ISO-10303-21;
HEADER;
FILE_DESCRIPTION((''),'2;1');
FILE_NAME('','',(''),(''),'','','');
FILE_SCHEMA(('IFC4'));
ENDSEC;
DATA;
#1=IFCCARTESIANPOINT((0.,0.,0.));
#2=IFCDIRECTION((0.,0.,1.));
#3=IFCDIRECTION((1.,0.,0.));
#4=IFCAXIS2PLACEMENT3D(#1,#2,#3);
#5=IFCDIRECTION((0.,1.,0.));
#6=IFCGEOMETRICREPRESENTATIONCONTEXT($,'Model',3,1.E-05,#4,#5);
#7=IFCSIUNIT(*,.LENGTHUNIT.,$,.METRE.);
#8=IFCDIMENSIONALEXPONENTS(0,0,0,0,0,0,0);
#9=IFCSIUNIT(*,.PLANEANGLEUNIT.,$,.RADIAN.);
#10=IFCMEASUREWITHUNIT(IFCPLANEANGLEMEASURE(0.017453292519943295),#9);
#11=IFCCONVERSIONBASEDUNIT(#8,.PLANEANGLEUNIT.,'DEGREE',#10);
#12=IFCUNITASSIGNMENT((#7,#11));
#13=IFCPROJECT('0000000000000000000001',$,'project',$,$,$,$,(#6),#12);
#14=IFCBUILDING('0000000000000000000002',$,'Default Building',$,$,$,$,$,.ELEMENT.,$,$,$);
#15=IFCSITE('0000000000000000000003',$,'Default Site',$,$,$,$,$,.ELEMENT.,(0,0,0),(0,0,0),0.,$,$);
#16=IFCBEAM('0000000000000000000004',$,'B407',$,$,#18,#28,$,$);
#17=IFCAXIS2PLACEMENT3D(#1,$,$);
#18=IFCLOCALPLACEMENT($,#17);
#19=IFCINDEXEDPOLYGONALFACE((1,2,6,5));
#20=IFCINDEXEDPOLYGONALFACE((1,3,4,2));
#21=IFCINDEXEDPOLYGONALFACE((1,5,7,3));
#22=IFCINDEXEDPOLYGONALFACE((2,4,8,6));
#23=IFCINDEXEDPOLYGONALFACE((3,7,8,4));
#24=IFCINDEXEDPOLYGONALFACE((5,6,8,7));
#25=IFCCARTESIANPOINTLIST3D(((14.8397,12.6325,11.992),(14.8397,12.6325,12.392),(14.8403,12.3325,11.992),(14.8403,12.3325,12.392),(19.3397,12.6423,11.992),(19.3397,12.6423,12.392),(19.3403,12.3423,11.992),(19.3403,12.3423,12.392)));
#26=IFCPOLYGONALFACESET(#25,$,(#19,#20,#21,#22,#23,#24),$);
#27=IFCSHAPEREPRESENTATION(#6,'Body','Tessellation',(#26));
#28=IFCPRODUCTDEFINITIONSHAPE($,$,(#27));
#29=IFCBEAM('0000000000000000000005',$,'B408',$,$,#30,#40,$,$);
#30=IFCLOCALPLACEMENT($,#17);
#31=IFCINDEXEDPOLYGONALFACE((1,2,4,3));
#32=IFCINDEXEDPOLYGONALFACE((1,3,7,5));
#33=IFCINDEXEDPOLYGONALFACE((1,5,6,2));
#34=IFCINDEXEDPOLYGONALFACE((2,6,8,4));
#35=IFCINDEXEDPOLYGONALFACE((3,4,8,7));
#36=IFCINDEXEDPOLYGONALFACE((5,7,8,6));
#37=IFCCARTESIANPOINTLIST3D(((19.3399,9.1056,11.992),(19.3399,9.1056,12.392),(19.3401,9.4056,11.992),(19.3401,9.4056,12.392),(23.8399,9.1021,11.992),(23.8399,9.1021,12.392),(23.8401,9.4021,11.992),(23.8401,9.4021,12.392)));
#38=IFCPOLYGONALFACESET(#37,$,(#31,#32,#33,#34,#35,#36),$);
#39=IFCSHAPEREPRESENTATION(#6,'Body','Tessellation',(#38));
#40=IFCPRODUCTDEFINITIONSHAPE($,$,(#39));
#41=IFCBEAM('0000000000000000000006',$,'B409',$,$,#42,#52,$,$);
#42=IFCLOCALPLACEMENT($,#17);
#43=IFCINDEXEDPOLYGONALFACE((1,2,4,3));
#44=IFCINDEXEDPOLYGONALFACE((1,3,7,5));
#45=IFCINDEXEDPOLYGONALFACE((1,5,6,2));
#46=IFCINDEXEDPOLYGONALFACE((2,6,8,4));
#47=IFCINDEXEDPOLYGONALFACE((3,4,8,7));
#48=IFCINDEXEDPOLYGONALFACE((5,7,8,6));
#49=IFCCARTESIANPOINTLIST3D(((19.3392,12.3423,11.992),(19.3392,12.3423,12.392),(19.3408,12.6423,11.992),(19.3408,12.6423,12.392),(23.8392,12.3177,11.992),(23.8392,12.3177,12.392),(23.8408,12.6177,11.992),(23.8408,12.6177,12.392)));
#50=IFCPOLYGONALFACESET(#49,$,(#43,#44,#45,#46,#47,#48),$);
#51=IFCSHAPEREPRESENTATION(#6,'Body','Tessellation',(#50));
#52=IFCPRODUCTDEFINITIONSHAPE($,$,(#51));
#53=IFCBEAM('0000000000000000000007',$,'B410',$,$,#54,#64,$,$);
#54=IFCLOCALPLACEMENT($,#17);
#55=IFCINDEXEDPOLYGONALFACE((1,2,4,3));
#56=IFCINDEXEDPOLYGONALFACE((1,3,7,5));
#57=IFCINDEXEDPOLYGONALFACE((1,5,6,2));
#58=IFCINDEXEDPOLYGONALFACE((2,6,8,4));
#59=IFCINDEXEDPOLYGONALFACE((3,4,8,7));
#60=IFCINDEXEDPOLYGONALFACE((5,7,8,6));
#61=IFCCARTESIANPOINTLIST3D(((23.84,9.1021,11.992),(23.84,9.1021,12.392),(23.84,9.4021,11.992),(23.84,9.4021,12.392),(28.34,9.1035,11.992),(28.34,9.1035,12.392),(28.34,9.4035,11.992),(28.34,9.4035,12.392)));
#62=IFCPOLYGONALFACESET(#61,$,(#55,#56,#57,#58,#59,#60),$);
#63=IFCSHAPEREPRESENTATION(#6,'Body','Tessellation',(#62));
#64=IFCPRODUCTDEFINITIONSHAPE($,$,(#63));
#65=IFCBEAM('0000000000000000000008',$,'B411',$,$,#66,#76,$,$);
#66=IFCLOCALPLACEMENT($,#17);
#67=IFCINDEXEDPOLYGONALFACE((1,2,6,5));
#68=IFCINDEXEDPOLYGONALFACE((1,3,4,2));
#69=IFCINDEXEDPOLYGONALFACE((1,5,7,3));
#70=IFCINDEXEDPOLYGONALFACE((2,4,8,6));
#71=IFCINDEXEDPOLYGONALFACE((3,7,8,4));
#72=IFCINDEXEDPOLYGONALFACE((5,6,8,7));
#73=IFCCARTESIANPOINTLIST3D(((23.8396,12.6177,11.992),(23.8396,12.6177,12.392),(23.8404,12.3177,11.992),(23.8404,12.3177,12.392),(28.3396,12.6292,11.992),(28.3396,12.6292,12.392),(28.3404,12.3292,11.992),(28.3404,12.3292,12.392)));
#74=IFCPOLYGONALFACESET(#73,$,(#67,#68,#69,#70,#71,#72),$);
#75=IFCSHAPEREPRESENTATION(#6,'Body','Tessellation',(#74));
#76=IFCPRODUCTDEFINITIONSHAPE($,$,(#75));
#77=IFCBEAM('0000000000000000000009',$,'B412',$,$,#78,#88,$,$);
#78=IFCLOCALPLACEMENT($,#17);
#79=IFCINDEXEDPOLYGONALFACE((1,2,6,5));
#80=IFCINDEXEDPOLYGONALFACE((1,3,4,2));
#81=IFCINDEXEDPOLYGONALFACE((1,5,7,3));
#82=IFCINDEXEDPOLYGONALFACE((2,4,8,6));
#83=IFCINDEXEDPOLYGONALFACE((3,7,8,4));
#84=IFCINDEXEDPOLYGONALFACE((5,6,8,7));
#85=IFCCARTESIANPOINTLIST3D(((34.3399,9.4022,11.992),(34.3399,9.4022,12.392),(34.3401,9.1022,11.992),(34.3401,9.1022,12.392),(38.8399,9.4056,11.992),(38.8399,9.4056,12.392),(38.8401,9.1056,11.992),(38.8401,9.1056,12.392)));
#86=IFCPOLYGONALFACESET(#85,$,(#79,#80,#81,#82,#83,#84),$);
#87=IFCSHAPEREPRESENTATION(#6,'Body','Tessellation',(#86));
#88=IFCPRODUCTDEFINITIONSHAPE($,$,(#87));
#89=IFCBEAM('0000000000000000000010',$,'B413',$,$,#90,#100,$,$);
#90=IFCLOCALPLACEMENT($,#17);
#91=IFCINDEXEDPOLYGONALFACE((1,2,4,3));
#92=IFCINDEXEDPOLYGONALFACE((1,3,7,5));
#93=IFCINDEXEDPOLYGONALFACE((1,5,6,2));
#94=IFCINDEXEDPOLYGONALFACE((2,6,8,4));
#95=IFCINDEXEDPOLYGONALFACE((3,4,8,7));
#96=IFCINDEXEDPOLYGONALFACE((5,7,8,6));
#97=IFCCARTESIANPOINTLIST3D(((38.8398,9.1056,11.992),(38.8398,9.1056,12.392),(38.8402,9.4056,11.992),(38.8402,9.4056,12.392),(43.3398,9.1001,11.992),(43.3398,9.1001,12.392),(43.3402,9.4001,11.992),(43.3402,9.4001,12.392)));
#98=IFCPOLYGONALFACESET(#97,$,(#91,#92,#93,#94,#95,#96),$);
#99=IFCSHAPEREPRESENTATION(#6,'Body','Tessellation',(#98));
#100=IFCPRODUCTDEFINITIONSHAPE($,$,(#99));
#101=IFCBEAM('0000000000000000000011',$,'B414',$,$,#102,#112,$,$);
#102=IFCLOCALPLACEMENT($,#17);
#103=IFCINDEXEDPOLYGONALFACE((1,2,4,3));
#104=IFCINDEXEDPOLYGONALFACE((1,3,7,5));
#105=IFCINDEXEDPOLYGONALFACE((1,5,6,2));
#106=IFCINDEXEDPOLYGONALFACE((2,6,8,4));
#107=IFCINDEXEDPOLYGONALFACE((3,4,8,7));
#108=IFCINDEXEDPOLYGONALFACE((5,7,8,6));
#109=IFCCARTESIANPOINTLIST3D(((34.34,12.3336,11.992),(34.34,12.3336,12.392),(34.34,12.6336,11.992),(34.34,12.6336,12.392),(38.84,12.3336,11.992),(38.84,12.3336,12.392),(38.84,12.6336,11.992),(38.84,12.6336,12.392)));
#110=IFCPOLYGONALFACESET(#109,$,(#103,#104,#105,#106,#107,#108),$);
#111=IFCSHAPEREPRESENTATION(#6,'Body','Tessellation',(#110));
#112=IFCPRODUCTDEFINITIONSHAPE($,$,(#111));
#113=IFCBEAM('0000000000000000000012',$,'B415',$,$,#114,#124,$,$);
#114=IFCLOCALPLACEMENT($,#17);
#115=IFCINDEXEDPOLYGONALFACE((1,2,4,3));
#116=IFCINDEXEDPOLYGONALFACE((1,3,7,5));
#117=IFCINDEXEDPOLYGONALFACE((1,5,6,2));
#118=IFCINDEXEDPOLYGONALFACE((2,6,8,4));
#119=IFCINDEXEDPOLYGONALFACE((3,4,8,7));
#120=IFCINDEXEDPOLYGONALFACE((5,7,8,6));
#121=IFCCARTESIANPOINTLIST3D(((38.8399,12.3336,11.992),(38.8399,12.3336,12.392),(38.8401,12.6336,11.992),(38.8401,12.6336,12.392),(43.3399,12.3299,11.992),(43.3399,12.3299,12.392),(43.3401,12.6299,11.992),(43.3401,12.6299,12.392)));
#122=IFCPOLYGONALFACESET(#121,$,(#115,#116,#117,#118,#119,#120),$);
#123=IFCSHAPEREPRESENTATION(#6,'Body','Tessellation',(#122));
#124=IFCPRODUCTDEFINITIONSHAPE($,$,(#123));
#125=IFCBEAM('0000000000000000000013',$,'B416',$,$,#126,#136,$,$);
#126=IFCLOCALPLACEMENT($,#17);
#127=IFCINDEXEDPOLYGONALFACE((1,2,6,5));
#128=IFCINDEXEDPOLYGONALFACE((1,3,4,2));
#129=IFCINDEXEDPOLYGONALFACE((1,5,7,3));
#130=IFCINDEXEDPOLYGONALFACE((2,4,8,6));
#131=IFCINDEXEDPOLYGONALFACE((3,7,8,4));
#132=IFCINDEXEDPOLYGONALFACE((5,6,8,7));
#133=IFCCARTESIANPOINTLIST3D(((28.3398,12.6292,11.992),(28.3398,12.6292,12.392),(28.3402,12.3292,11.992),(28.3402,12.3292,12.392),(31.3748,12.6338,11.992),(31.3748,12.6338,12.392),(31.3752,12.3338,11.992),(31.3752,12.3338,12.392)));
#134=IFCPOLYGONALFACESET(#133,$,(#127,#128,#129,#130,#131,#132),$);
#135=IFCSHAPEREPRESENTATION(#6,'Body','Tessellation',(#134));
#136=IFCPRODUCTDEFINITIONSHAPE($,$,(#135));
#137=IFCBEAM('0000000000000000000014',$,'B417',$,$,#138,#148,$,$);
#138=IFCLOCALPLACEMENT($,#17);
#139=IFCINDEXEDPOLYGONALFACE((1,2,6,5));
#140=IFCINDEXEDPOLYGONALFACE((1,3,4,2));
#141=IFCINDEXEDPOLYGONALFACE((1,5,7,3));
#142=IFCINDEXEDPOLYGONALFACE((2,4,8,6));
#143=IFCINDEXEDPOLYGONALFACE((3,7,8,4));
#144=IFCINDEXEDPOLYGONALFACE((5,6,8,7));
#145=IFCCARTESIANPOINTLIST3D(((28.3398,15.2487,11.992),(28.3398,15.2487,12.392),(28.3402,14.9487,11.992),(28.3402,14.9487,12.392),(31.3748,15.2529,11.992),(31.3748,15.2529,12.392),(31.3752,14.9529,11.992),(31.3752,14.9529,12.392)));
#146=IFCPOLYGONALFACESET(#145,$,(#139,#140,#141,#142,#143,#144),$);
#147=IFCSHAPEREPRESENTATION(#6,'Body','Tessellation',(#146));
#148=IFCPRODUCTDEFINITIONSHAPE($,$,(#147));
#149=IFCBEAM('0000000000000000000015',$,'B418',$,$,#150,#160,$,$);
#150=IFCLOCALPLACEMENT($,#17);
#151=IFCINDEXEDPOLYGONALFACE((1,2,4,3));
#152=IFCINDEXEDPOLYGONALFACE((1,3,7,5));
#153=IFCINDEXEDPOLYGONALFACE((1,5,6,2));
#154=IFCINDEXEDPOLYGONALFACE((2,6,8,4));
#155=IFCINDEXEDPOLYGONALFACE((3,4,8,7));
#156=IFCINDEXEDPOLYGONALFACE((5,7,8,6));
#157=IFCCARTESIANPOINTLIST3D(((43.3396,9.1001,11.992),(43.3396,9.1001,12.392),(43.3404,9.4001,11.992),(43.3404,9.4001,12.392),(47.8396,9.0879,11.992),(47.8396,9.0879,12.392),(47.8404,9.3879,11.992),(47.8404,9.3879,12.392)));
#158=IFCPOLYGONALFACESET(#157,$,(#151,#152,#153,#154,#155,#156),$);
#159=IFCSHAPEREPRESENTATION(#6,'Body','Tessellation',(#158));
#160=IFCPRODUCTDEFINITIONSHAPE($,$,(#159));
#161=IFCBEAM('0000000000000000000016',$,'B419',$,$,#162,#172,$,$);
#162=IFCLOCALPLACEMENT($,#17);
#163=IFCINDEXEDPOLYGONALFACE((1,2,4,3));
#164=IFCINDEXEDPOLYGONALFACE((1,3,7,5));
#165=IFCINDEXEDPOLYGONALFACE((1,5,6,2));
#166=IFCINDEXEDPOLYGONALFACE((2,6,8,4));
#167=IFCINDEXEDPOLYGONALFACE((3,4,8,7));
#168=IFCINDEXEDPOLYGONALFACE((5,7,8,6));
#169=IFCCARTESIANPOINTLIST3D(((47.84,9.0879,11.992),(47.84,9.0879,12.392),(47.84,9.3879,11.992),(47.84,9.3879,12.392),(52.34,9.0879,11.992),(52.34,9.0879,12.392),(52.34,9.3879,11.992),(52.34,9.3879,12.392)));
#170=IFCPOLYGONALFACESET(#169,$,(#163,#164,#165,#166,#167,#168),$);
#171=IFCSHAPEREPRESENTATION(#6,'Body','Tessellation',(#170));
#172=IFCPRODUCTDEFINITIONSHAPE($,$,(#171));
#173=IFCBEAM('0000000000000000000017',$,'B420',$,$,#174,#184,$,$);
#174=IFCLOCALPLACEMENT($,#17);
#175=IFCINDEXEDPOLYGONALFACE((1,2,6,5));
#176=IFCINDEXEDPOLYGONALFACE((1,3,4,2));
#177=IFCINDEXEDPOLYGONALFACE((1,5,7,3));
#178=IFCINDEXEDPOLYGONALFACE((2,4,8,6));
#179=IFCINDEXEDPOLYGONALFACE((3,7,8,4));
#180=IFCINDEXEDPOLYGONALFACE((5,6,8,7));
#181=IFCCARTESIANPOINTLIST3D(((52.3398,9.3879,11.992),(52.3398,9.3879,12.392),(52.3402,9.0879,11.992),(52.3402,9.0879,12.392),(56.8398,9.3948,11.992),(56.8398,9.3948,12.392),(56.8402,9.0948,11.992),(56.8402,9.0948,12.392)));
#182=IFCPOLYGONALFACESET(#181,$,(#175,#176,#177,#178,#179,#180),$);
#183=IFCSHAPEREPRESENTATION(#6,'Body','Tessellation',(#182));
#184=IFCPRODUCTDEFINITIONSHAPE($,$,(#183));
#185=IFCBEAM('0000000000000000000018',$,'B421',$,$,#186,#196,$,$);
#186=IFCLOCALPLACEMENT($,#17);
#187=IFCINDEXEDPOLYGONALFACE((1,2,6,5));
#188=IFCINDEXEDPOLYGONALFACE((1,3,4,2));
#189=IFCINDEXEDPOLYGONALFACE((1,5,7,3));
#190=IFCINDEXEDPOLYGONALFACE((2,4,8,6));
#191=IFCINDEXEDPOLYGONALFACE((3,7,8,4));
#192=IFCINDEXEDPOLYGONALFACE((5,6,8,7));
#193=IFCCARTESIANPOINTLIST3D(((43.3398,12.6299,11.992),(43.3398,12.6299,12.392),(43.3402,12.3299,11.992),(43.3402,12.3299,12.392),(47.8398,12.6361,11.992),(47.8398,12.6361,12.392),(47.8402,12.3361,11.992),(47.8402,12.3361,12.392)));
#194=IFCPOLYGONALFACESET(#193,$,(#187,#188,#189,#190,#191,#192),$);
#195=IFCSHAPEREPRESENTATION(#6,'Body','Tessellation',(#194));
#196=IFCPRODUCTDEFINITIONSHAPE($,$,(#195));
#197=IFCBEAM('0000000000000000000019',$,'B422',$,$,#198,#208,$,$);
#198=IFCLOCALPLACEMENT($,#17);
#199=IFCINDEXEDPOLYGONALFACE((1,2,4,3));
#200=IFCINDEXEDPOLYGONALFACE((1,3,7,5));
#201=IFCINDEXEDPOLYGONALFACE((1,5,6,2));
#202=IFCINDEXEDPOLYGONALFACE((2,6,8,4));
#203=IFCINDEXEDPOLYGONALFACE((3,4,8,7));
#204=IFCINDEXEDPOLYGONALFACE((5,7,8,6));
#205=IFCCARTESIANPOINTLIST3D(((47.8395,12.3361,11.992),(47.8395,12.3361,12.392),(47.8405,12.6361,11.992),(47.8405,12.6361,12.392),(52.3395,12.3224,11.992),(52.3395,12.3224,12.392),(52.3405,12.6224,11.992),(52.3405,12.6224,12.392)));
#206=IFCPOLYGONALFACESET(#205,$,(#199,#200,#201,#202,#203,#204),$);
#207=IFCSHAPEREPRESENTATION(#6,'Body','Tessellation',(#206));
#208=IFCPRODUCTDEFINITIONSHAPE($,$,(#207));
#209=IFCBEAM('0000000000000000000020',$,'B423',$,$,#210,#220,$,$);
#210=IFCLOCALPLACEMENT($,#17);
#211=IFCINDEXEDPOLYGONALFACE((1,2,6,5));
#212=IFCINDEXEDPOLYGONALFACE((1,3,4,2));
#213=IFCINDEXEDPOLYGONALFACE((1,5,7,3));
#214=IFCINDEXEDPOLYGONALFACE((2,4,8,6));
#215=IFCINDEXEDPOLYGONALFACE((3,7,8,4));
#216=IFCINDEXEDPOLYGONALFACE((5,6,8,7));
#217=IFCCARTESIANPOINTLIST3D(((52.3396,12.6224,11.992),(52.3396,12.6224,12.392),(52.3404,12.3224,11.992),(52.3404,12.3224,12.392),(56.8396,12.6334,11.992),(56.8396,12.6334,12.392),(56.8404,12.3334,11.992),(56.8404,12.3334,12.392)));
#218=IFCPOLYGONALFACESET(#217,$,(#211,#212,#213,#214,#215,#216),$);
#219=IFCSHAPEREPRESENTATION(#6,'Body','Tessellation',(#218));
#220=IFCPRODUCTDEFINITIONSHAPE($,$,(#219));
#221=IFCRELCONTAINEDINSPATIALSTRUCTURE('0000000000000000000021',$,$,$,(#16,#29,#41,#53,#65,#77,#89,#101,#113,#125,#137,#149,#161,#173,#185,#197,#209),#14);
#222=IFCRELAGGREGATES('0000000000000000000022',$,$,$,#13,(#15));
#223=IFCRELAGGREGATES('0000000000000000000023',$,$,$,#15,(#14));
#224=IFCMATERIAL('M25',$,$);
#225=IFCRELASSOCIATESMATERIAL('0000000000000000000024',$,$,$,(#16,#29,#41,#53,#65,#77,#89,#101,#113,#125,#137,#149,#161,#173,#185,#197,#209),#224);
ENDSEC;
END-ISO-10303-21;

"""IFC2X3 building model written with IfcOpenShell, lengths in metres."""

from ifc_helpers import new_model, entity, si_unit, converted_unit, direction, frame, frame_2d, origin_with_axes, place, context, project, spatial, rectangle, extrude, material, element, save


model = new_model("IFC2X3")

# Units and contexts
model_context = context("Model", 3, precision=1e-05, world=origin_with_axes(), true_north=direction((0.0, 1.0, 0.0)))
ifc_project = project(units=[si_unit("LENGTHUNIT", "METRE"), converted_unit("PLANEANGLEUNIT", "DEGREE", entity("IfcPlaneAngleMeasure", 0.017453292519943295), si_unit("PLANEANGLEUNIT", "RADIAN"), dimensions=[0, 0, 0, 0, 0, 0, 0])], contexts=[model_context])

# Site, building
site = spatial("IfcSite", under=ifc_project, Name="Default Site", CompositionType="ELEMENT", RefLatitude=(0, 0, 0), RefLongitude=(0, 0, 0), RefElevation=0.0)
building = spatial("IfcBuilding", under=site, Name="Default Building", CompositionType="ELEMENT")

# Beams
ifc_material = material(Name="M25")
placement = place(None, origin_with_axes())
element("IfcBeam", 1, at=placement, inside=building, material=ifc_material, Name="B407", context=model_context, shape_type="SweptSolid", body=[
    extrude(rectangle(XDim=0.3, YDim=0.4, at=frame_2d((0.0, 0.0), x_axis=(0.0, 1.0, 0.0))), frame((14.84, 12.4825, 12.192), z_axis=(0.999998, 0.002176, 0.0), x_axis=(0.0, 0.0, -1.0)), (0.0, 0.0, 1.0), 4.5),
])
element("IfcBeam", 2, at=placement, inside=building, material=ifc_material, Name="B408", context=model_context, shape_type="SweptSolid", body=[
    extrude(rectangle(XDim=0.3, YDim=0.4, at=frame_2d((0.0, 0.0), x_axis=(0.0, 1.0, 0.0))), frame((19.34, 9.2556, 12.192), z_axis=(1.0, -0.000779, 0.0), x_axis=(0.0, 0.0, -1.0)), (0.0, 0.0, 1.0), 4.5),
])
element("IfcBeam", 3, at=placement, inside=building, material=ifc_material, Name="B409", context=model_context, shape_type="SweptSolid", body=[
    extrude(rectangle(XDim=0.3, YDim=0.4, at=frame_2d((0.0, 0.0), x_axis=(0.0, 1.0, 0.0))), frame((19.34, 12.4923, 12.192), z_axis=(0.999985, -0.005463, 0.0), x_axis=(0.0, 0.0, -1.0)), (0.0, 0.0, 1.0), 4.5001),
])
element("IfcBeam", 4, at=placement, inside=building, material=ifc_material, Name="B410", context=model_context, shape_type="SweptSolid", body=[
    extrude(rectangle(XDim=0.3, YDim=0.4, at=frame_2d((0.0, 0.0), x_axis=(0.0, 1.0, 0.0))), frame((23.84, 9.2521, 12.192), z_axis=(1.0, 0.000307, 0.0), x_axis=(0.0, 0.0, -1.0)), (0.0, 0.0, 1.0), 4.5),
])
element("IfcBeam", 5, at=placement, inside=building, material=ifc_material, Name="B411", context=model_context, shape_type="SweptSolid", body=[
    extrude(rectangle(XDim=0.3, YDim=0.4, at=frame_2d((0.0, 0.0), x_axis=(0.0, 1.0, 0.0))), frame((23.84, 12.4677, 12.192), z_axis=(0.999997, 0.002551, 0.0), x_axis=(0.0, 0.0, -1.0)), (0.0, 0.0, 1.0), 4.5),
])
element("IfcBeam", 6, at=placement, inside=building, material=ifc_material, Name="B412", context=model_context, shape_type="SweptSolid", body=[
    extrude(rectangle(XDim=0.3, YDim=0.4, at=frame_2d((0.0, 0.0), x_axis=(0.0, 1.0, 0.0))), frame((34.34, 9.2522, 12.192), z_axis=(1.0, 0.000748, 0.0), x_axis=(0.0, 0.0, -1.0)), (0.0, 0.0, 1.0), 4.5),
])
element("IfcBeam", 7, at=placement, inside=building, material=ifc_material, Name="B413", context=model_context, shape_type="SweptSolid", body=[
    extrude(rectangle(XDim=0.3, YDim=0.4, at=frame_2d((0.0, 0.0), x_axis=(0.0, 1.0, 0.0))), frame((38.84, 9.2556, 12.192), z_axis=(0.999999, -0.001227, 0.0), x_axis=(0.0, 0.0, -1.0)), (0.0, 0.0, 1.0), 4.5),
])
element("IfcBeam", 8, at=placement, inside=building, material=ifc_material, Name="B414", context=model_context, shape_type="SweptSolid", body=[
    extrude(rectangle(XDim=0.3, YDim=0.4, at=frame_2d((0.0, 0.0), x_axis=(0.0, 1.0, 0.0))), frame((34.34, 12.4836, 12.192), z_axis=(1.0, -0.000008, 0.0), x_axis=(0.0, 0.0, -1.0)), (0.0, 0.0, 1.0), 4.5),
])
element("IfcBeam", 9, at=placement, inside=building, material=ifc_material, Name="B415", context=model_context, shape_type="SweptSolid", body=[
    extrude(rectangle(XDim=0.3, YDim=0.4, at=frame_2d((0.0, 0.0), x_axis=(0.0, 1.0, 0.0))), frame((38.84, 12.4836, 12.192), z_axis=(1.0, -0.000826, 0.0), x_axis=(0.0, 0.0, -1.0)), (0.0, 0.0, 1.0), 4.5),
])
element("IfcBeam", 10, at=placement, inside=building, material=ifc_material, Name="B416", context=model_context, shape_type="SweptSolid", body=[
    extrude(rectangle(XDim=0.3, YDim=0.4, at=frame_2d((0.0, 0.0), x_axis=(0.0, 1.0, 0.0))), frame((28.34, 12.4792, 12.192), z_axis=(0.999999, 0.001542, 0.0), x_axis=(0.0, 0.0, -1.0)), (0.0, 0.0, 1.0), 3.035),
])
element("IfcBeam", 11, at=placement, inside=building, material=ifc_material, Name="B417", context=model_context, shape_type="SweptSolid", body=[
    extrude(rectangle(XDim=0.3, YDim=0.4, at=frame_2d((0.0, 0.0), x_axis=(0.0, 1.0, 0.0))), frame((31.375, 15.1029, 12.192), z_axis=(-0.999999, -0.001391, 0.0), x_axis=(0.0, 0.0, -1.0)), (0.0, 0.0, 1.0), 3.035),
])
element("IfcBeam", 12, at=placement, inside=building, material=ifc_material, Name="B418", context=model_context, shape_type="SweptSolid", body=[
    extrude(rectangle(XDim=0.3, YDim=0.4, at=frame_2d((0.0, 0.0), x_axis=(0.0, 1.0, 0.0))), frame((43.34, 9.2501, 12.192), z_axis=(0.999996, -0.002702, 0.0), x_axis=(0.0, 0.0, -1.0)), (0.0, 0.0, 1.0), 4.5),
])
element("IfcBeam", 13, at=placement, inside=building, material=ifc_material, Name="B419", context=model_context, shape_type="SweptSolid", body=[
    extrude(rectangle(XDim=0.3, YDim=0.4, at=frame_2d((0.0, 0.0), x_axis=(0.0, 1.0, 0.0))), frame((47.84, 9.2379, 12.192), z_axis=(1.0, 0.0, 0.0), x_axis=(0.0, 0.0, -1.0)), (0.0, 0.0, 1.0), 4.5),
])
element("IfcBeam", 14, at=placement, inside=building, material=ifc_material, Name="B420", context=model_context, shape_type="SweptSolid", body=[
    extrude(rectangle(XDim=0.3, YDim=0.4, at=frame_2d((0.0, 0.0), x_axis=(0.0, 1.0, 0.0))), frame((52.34, 9.2379, 12.192), z_axis=(0.999999, 0.001537, 0.0), x_axis=(0.0, 0.0, -1.0)), (0.0, 0.0, 1.0), 4.5),
])
element("IfcBeam", 15, at=placement, inside=building, material=ifc_material, Name="B421", context=model_context, shape_type="SweptSolid", body=[
    extrude(rectangle(XDim=0.3, YDim=0.4, at=frame_2d((0.0, 0.0), x_axis=(0.0, 1.0, 0.0))), frame((43.34, 12.4799, 12.192), z_axis=(0.999999, 0.001374, 0.0), x_axis=(0.0, 0.0, -1.0)), (0.0, 0.0, 1.0), 4.5),
])
element("IfcBeam", 16, at=placement, inside=building, material=ifc_material, Name="B422", context=model_context, shape_type="SweptSolid", body=[
    extrude(rectangle(XDim=0.3, YDim=0.4, at=frame_2d((0.0, 0.0), x_axis=(0.0, 1.0, 0.0))), frame((47.84, 12.4861, 12.192), z_axis=(0.999995, -0.003045, 0.0), x_axis=(0.0, 0.0, -1.0)), (0.0, 0.0, 1.0), 4.5),
])
element("IfcBeam", 17, at=placement, inside=building, material=ifc_material, Name="B423", context=model_context, shape_type="SweptSolid", body=[
    extrude(rectangle(XDim=0.3, YDim=0.4, at=frame_2d((0.0, 0.0), x_axis=(0.0, 1.0, 0.0))), frame((52.34, 12.4724, 12.192), z_axis=(0.999997, 0.002456, 0.0), x_axis=(0.0, 0.0, -1.0)), (0.0, 0.0, 1.0), 4.5),
])

save(model, "model.ifc")
